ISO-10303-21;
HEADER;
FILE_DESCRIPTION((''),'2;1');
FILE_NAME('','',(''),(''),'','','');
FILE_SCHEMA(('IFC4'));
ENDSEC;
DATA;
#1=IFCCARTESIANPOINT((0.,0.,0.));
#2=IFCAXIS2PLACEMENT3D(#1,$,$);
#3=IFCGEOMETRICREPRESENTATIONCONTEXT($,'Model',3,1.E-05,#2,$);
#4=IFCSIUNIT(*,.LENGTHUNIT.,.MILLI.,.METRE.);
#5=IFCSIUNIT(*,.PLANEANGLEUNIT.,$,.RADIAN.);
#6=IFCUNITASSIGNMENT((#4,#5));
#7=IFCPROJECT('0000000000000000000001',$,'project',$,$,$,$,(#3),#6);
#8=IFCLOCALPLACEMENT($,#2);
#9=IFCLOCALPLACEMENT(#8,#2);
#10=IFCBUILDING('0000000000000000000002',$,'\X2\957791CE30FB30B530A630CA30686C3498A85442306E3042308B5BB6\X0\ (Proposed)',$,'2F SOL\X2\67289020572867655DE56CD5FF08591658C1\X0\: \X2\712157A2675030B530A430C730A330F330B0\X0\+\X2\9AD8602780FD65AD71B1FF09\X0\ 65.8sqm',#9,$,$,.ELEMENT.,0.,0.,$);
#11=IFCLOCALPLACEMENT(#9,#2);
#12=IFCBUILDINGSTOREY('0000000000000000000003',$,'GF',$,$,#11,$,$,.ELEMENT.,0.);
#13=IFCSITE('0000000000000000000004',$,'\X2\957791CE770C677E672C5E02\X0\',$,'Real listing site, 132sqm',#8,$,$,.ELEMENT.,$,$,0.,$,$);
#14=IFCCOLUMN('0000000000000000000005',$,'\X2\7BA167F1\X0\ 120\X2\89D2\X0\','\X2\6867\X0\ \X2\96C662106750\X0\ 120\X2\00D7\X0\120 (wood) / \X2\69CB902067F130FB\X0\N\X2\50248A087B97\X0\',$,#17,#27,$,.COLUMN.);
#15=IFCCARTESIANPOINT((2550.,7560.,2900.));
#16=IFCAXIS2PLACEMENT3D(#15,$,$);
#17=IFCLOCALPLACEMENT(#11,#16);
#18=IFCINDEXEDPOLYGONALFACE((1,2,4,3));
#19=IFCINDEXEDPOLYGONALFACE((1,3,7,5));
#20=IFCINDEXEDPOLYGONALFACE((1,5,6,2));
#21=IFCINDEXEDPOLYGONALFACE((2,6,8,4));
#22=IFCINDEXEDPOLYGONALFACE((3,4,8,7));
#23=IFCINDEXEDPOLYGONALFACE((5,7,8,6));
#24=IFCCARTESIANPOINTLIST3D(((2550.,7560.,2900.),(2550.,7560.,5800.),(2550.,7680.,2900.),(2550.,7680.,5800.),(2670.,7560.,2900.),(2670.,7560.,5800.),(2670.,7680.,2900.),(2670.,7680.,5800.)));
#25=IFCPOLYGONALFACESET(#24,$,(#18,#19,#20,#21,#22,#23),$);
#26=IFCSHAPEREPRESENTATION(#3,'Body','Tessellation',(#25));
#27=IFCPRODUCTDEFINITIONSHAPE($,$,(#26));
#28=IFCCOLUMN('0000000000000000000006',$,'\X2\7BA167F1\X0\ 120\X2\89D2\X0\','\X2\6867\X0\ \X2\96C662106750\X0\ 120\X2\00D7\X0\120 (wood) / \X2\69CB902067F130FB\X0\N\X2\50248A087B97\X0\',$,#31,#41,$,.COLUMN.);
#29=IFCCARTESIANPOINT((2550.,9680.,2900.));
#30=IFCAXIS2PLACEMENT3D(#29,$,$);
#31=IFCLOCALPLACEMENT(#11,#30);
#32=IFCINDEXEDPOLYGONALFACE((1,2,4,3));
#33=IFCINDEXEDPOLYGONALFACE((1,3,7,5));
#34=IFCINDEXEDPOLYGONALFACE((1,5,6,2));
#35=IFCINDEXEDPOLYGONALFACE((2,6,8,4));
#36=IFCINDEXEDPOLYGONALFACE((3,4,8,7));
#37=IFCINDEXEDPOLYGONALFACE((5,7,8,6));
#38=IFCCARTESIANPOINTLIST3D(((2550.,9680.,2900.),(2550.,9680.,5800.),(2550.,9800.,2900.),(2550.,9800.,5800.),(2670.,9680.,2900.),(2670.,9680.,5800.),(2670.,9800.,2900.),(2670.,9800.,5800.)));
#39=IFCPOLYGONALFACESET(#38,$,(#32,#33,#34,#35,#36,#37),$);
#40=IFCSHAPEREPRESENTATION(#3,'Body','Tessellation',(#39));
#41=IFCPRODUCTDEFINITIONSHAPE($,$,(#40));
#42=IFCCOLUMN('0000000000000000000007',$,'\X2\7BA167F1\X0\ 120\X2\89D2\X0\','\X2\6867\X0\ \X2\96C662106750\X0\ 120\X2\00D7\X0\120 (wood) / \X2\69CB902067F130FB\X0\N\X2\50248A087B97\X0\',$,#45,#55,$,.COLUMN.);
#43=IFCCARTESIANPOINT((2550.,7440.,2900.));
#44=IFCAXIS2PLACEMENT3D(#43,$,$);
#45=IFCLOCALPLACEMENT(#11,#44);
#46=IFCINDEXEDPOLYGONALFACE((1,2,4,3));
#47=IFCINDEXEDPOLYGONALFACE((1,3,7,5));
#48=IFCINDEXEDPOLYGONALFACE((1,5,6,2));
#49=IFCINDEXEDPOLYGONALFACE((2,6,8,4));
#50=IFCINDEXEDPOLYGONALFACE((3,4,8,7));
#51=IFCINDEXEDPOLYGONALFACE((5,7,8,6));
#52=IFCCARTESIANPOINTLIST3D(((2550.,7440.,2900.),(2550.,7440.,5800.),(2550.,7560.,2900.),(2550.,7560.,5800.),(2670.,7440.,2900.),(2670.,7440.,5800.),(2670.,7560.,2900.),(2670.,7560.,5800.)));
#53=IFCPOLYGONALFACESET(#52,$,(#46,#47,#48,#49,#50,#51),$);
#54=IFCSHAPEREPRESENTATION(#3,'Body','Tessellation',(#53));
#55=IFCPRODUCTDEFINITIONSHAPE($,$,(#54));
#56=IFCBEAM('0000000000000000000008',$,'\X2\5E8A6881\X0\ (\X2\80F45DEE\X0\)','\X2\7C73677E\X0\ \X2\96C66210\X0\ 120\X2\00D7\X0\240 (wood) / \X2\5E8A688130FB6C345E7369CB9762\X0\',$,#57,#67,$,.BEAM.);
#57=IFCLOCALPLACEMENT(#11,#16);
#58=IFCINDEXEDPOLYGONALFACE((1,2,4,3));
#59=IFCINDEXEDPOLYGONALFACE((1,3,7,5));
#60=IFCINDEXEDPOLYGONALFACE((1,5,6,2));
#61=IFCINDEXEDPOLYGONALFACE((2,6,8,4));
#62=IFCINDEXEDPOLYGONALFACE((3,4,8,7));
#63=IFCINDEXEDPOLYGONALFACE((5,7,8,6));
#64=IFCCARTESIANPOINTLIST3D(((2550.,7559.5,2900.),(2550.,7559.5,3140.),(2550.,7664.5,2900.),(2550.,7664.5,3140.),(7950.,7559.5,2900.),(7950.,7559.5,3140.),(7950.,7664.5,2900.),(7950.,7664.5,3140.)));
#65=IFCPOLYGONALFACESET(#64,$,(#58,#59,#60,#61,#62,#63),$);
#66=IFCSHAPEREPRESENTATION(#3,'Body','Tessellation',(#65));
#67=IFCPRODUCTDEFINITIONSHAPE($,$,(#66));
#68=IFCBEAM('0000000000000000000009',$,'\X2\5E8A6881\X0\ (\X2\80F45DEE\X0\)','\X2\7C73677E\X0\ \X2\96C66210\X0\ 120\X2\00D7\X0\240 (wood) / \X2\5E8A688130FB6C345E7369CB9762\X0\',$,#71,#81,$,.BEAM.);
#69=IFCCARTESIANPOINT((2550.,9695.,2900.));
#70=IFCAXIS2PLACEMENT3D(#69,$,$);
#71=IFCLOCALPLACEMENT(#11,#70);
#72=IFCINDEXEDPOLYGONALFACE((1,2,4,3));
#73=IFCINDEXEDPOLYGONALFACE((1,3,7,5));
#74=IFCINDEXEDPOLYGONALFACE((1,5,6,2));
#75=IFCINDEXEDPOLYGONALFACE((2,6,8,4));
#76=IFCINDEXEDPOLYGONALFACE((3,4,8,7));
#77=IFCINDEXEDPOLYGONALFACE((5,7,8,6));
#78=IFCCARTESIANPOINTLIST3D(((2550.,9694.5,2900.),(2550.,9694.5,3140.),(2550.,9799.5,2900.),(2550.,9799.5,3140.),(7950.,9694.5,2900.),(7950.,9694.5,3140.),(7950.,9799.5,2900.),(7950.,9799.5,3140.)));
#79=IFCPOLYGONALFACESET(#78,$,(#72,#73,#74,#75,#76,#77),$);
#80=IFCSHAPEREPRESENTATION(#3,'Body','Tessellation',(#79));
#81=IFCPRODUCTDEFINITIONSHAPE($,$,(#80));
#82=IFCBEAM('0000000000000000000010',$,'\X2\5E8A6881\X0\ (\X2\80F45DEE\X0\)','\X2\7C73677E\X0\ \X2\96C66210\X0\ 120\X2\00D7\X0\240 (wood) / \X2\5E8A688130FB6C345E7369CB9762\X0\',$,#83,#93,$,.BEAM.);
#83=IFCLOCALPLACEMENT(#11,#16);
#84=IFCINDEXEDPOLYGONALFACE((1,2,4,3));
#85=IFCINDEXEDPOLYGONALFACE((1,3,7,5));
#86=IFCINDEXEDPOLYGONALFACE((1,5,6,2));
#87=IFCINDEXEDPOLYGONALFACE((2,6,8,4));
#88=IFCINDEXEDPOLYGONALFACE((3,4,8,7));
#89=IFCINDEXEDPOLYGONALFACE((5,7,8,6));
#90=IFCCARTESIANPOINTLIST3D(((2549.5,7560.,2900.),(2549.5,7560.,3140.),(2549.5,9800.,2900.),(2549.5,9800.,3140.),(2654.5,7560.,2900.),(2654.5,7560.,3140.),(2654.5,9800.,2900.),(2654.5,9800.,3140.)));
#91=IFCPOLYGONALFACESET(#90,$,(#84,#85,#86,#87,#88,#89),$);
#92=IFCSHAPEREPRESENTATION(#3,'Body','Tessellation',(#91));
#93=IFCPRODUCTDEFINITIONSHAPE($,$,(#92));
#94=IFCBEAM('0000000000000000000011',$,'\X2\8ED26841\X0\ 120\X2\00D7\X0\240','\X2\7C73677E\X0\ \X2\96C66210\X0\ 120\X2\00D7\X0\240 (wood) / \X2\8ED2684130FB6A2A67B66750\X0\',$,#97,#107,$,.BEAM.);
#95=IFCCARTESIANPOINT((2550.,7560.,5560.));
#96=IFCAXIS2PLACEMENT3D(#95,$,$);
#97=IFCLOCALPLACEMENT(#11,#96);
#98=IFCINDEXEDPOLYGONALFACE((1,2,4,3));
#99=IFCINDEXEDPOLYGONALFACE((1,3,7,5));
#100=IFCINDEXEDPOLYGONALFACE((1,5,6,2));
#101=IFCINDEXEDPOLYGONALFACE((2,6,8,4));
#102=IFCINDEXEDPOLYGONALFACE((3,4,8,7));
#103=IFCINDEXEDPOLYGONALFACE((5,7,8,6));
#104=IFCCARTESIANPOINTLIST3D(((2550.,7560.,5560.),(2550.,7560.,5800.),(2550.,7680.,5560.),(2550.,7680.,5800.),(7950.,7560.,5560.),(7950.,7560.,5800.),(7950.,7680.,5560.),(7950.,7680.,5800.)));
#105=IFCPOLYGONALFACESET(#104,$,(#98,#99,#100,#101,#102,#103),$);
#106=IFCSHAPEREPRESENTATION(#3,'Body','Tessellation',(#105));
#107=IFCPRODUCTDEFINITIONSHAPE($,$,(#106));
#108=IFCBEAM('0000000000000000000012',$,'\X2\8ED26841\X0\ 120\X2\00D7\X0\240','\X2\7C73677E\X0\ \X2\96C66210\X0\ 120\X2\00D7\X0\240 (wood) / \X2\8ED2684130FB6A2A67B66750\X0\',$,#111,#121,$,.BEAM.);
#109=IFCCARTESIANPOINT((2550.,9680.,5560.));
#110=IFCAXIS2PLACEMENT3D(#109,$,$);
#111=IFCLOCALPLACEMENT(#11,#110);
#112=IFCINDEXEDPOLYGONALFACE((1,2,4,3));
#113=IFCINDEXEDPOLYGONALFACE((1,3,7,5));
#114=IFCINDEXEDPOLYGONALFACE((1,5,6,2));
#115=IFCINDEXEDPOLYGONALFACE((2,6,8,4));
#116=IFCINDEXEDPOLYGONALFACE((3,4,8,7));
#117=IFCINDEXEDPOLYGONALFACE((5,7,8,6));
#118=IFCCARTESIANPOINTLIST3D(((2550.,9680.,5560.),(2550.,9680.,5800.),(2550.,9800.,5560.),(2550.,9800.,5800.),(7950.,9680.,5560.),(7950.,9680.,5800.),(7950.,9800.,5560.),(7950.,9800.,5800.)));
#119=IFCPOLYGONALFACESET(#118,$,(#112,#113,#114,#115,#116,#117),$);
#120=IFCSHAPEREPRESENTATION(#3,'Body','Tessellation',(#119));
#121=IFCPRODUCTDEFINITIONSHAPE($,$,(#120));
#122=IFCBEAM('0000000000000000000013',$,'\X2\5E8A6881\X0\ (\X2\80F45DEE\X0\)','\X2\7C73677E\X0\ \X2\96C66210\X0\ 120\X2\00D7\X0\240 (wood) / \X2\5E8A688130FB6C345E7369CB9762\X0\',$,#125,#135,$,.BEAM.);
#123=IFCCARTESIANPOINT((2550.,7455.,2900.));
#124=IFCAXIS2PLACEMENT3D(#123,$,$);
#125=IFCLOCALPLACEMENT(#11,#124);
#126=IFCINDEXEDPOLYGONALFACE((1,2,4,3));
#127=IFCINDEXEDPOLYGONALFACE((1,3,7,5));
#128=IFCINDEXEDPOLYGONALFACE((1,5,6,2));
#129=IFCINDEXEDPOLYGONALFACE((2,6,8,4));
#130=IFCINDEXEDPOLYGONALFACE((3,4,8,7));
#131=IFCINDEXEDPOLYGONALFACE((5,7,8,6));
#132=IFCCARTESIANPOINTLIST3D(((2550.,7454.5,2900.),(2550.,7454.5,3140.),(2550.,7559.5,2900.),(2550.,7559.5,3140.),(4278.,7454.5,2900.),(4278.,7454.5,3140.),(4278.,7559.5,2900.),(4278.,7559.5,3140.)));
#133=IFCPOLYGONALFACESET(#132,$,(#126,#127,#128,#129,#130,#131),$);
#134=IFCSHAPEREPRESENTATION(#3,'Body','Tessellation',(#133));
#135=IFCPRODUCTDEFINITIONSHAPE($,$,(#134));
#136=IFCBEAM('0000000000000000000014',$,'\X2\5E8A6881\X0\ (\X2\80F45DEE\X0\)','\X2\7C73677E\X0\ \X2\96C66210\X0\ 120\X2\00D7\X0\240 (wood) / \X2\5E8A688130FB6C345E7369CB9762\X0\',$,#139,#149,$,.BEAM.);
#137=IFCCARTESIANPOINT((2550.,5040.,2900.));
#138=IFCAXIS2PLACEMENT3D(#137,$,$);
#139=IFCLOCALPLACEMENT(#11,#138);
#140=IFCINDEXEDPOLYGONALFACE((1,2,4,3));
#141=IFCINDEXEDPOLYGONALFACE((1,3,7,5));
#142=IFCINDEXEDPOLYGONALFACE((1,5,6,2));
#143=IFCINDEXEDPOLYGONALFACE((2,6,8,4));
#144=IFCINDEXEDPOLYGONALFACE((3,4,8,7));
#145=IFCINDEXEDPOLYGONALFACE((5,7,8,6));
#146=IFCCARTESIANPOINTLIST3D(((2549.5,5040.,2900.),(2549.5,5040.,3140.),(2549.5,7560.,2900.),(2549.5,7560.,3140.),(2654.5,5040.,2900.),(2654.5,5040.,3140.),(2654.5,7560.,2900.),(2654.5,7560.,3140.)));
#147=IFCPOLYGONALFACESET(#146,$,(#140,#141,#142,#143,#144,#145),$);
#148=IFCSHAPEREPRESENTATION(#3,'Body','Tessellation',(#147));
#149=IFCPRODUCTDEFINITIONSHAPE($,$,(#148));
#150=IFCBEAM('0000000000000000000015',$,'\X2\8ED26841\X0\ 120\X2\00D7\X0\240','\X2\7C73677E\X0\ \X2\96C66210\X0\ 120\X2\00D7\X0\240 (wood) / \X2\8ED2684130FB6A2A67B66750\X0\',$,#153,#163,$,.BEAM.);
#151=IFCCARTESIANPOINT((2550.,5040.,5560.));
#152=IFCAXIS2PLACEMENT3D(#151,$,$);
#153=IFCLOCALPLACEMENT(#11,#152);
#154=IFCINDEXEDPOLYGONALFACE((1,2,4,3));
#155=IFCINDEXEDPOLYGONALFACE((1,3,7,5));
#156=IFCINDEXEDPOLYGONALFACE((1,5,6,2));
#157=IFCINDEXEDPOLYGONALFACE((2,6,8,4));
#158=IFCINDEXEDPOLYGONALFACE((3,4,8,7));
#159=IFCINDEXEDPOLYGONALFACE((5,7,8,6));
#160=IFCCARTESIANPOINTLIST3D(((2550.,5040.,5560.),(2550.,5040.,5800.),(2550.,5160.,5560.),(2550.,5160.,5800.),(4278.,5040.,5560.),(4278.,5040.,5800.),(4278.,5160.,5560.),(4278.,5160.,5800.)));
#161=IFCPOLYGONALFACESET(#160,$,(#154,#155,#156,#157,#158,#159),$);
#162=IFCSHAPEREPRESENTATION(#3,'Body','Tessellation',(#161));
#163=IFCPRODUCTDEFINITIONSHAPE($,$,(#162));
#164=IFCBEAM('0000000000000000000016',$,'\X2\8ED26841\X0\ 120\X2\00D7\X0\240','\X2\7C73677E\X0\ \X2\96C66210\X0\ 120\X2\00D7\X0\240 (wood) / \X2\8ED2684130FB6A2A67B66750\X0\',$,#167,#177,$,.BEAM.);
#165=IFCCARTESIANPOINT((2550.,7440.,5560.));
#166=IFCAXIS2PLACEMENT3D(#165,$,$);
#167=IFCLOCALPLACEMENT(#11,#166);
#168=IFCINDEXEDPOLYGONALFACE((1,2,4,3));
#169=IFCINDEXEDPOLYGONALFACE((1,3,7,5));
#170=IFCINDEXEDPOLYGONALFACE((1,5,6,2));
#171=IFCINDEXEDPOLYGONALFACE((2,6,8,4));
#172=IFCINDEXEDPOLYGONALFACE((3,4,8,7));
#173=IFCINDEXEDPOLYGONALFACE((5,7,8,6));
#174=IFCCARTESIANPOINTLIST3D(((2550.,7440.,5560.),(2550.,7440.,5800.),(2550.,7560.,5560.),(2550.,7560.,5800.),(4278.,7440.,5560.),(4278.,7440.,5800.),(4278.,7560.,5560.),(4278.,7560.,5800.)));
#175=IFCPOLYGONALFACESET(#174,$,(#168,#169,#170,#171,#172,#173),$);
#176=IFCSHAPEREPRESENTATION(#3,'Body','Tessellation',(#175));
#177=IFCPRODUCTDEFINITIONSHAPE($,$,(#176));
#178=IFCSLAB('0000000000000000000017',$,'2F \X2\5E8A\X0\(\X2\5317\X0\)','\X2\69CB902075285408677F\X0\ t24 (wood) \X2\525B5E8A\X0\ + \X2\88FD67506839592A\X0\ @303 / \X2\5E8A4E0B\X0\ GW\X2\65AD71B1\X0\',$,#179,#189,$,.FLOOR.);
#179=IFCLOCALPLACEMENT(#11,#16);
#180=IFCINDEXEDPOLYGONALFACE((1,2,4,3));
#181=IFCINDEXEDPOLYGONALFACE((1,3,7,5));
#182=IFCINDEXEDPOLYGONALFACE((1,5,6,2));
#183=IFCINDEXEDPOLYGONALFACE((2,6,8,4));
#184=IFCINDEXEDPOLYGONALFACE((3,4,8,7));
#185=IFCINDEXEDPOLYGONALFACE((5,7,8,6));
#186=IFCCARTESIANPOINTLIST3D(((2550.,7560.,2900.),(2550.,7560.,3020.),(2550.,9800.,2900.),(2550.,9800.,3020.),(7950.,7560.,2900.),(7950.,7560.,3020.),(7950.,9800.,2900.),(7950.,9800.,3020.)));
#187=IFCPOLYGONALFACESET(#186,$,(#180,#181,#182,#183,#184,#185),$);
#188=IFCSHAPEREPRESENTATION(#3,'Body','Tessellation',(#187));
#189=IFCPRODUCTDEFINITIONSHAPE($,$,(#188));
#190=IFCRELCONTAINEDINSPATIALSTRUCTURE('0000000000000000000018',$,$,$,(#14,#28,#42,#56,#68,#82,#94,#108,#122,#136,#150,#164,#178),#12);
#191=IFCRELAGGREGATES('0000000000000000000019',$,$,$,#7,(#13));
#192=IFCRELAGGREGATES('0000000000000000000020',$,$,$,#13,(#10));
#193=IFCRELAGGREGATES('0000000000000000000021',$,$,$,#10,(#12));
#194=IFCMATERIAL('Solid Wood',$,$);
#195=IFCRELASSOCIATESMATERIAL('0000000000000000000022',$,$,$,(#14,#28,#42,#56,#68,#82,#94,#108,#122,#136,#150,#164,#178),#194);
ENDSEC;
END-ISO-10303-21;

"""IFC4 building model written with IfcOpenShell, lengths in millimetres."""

from ifc_helpers import new_model, si_unit, frame, frame_2d, origin, place, context, project, spatial, rectangle, extrude, material, element, save


model = new_model("IFC4")

# Units and contexts
model_context = context("Model", 3, precision=1e-05, world=origin())
ifc_project = project(units=[si_unit("LENGTHUNIT", "METRE", prefix="MILLI"), si_unit("PLANEANGLEUNIT", "RADIAN")], contexts=[model_context])

# Site, building, storey
site_placement = place(None, origin())
site = spatial("IfcSite", under=ifc_project, at=site_placement, Name="長野県松本市", ObjectType="Real listing site, 132sqm", CompositionType="ELEMENT", RefElevation=0.0)
building_placement = place(site_placement, origin())
building = spatial("IfcBuilding", under=site, at=building_placement, Name="長野・サウナと水風呂のある家 (Proposed)", ObjectType="2F SOL木造在来工法（外壁: 無垢材サイディング+高性能断熱） 65.8sqm", CompositionType="ELEMENT", ElevationOfRefHeight=0.0, ElevationOfTerrain=0.0)
storey_placement = place(building_placement, origin())
storey = spatial("IfcBuildingStorey", under=building, at=storey_placement, Name="GF", CompositionType="ELEMENT", Elevation=0.0)

# Columns
ifc_material_1 = material(Name="Solid Wood")
column_1_placement = place(storey_placement, frame((2550.0, 7560.0, 2900.0)))
element("IfcColumn", 1, at=column_1_placement, inside=storey, material=ifc_material_1, Name="管柱 120角", Description="桧 集成材 120×120 (wood) / 構造柱・N値計算", PredefinedType="COLUMN", context=model_context, shape_type="SweptSolid", body=[
    extrude(rectangle(XDim=120.0, YDim=120.0, at=frame_2d((60.0, 60.0))), frame((2550.0, 7560.0, 2900.0)), (0.0, 0.0, 1.0), 2900.0),
])
column_2_placement = place(storey_placement, frame((2550.0, 9680.0, 2900.0)))
element("IfcColumn", 2, at=column_2_placement, inside=storey, material=ifc_material_1, Name="管柱 120角", Description="桧 集成材 120×120 (wood) / 構造柱・N値計算", PredefinedType="COLUMN", context=model_context, shape_type="SweptSolid", body=[
    extrude(rectangle(XDim=120.0, YDim=120.0, at=frame_2d((60.0, 60.0))), frame((2550.0, 9680.0, 2900.0)), (0.0, 0.0, 1.0), 2900.0),
])
column_3_placement = place(storey_placement, frame((2550.0, 7440.0, 2900.0)))
element("IfcColumn", 3, at=column_3_placement, inside=storey, material=ifc_material_1, Name="管柱 120角", Description="桧 集成材 120×120 (wood) / 構造柱・N値計算", PredefinedType="COLUMN", context=model_context, shape_type="SweptSolid", body=[
    extrude(rectangle(XDim=120.0, YDim=120.0, at=frame_2d((60.0, 60.0))), frame((2550.0, 7440.0, 2900.0)), (0.0, 0.0, 1.0), 2900.0),
])

# Beams
beam_1_placement = place(storey_placement, frame((2550.0, 7560.0, 2900.0)))
element("IfcBeam", 4, at=beam_1_placement, inside=storey, material=ifc_material_1, Name="床梁 (胴差)", Description="米松 集成 120×240 (wood) / 床梁・水平構面", PredefinedType="BEAM", context=model_context, shape_type="SweptSolid", body=[
    extrude(rectangle(XDim=5400.0, YDim=105.0, at=frame_2d((2700.0, 52.0))), frame((2550.0, 7560.0, 2900.0)), (0.0, 0.0, 1.0), 240.0),
])
beam_2_placement = place(storey_placement, frame((2550.0, 9695.0, 2900.0)))
element("IfcBeam", 5, at=beam_2_placement, inside=storey, material=ifc_material_1, Name="床梁 (胴差)", Description="米松 集成 120×240 (wood) / 床梁・水平構面", PredefinedType="BEAM", context=model_context, shape_type="SweptSolid", body=[
    extrude(rectangle(XDim=5400.0, YDim=105.0, at=frame_2d((2700.0, 52.0))), frame((2550.0, 9695.0, 2900.0)), (0.0, 0.0, 1.0), 240.0),
])
beam_3_placement = place(storey_placement, frame((2550.0, 7560.0, 2900.0)))
element("IfcBeam", 6, at=beam_3_placement, inside=storey, material=ifc_material_1, Name="床梁 (胴差)", Description="米松 集成 120×240 (wood) / 床梁・水平構面", PredefinedType="BEAM", context=model_context, shape_type="SweptSolid", body=[
    extrude(rectangle(XDim=105.0, YDim=2240.0, at=frame_2d((52.0, 1120.0))), frame((2550.0, 7560.0, 2900.0)), (0.0, 0.0, 1.0), 240.0),
])
beam_4_placement = place(storey_placement, frame((2550.0, 7560.0, 5560.0)))
element("IfcBeam", 7, at=beam_4_placement, inside=storey, material=ifc_material_1, Name="軒桁 120×240", Description="米松 集成 120×240 (wood) / 軒桁・横架材", PredefinedType="BEAM", context=model_context, shape_type="SweptSolid", body=[
    extrude(rectangle(XDim=5400.0, YDim=120.0, at=frame_2d((2700.0, 60.0))), frame((2550.0, 7560.0, 5560.0)), (0.0, 0.0, 1.0), 240.0),
])
beam_5_placement = place(storey_placement, frame((2550.0, 9680.0, 5560.0)))
element("IfcBeam", 8, at=beam_5_placement, inside=storey, material=ifc_material_1, Name="軒桁 120×240", Description="米松 集成 120×240 (wood) / 軒桁・横架材", PredefinedType="BEAM", context=model_context, shape_type="SweptSolid", body=[
    extrude(rectangle(XDim=5400.0, YDim=120.0, at=frame_2d((2700.0, 60.0))), frame((2550.0, 9680.0, 5560.0)), (0.0, 0.0, 1.0), 240.0),
])
beam_6_placement = place(storey_placement, frame((2550.0, 7455.0, 2900.0)))
element("IfcBeam", 9, at=beam_6_placement, inside=storey, material=ifc_material_1, Name="床梁 (胴差)", Description="米松 集成 120×240 (wood) / 床梁・水平構面", PredefinedType="BEAM", context=model_context, shape_type="SweptSolid", body=[
    extrude(rectangle(XDim=1728.0, YDim=105.0, at=frame_2d((864.0, 52.0))), frame((2550.0, 7455.0, 2900.0)), (0.0, 0.0, 1.0), 240.0),
])
beam_7_placement = place(storey_placement, frame((2550.0, 5040.0, 2900.0)))
element("IfcBeam", 10, at=beam_7_placement, inside=storey, material=ifc_material_1, Name="床梁 (胴差)", Description="米松 集成 120×240 (wood) / 床梁・水平構面", PredefinedType="BEAM", context=model_context, shape_type="SweptSolid", body=[
    extrude(rectangle(XDim=105.0, YDim=2520.0, at=frame_2d((52.0, 1260.0))), frame((2550.0, 5040.0, 2900.0)), (0.0, 0.0, 1.0), 240.0),
])
beam_8_placement = place(storey_placement, frame((2550.0, 5040.0, 5560.0)))
element("IfcBeam", 11, at=beam_8_placement, inside=storey, material=ifc_material_1, Name="軒桁 120×240", Description="米松 集成 120×240 (wood) / 軒桁・横架材", PredefinedType="BEAM", context=model_context, shape_type="SweptSolid", body=[
    extrude(rectangle(XDim=1728.0, YDim=120.0, at=frame_2d((864.0, 60.0))), frame((2550.0, 5040.0, 5560.0)), (0.0, 0.0, 1.0), 240.0),
])
beam_9_placement = place(storey_placement, frame((2550.0, 7440.0, 5560.0)))
element("IfcBeam", 12, at=beam_9_placement, inside=storey, material=ifc_material_1, Name="軒桁 120×240", Description="米松 集成 120×240 (wood) / 軒桁・横架材", PredefinedType="BEAM", context=model_context, shape_type="SweptSolid", body=[
    extrude(rectangle(XDim=1728.0, YDim=120.0, at=frame_2d((864.0, 60.0))), frame((2550.0, 7440.0, 5560.0)), (0.0, 0.0, 1.0), 240.0),
])

# Slab
slab_placement = place(storey_placement, frame((2550.0, 7560.0, 2900.0)))
element("IfcSlab", 13, at=slab_placement, inside=storey, material=ifc_material_1, Name="2F 床(北)", Description="構造用合板 t24 (wood) 剛床 + 製材根太 @303 / 床下 GW断熱", PredefinedType="FLOOR", context=model_context, shape_type="SweptSolid", body=[
    extrude(rectangle(XDim=5400.0, YDim=2240.0, at=frame_2d((2700.0, 1120.0))), frame((2550.0, 7560.0, 2900.0)), (0.0, 0.0, 1.0), 120.0),
])

save(model, "model.ifc")
